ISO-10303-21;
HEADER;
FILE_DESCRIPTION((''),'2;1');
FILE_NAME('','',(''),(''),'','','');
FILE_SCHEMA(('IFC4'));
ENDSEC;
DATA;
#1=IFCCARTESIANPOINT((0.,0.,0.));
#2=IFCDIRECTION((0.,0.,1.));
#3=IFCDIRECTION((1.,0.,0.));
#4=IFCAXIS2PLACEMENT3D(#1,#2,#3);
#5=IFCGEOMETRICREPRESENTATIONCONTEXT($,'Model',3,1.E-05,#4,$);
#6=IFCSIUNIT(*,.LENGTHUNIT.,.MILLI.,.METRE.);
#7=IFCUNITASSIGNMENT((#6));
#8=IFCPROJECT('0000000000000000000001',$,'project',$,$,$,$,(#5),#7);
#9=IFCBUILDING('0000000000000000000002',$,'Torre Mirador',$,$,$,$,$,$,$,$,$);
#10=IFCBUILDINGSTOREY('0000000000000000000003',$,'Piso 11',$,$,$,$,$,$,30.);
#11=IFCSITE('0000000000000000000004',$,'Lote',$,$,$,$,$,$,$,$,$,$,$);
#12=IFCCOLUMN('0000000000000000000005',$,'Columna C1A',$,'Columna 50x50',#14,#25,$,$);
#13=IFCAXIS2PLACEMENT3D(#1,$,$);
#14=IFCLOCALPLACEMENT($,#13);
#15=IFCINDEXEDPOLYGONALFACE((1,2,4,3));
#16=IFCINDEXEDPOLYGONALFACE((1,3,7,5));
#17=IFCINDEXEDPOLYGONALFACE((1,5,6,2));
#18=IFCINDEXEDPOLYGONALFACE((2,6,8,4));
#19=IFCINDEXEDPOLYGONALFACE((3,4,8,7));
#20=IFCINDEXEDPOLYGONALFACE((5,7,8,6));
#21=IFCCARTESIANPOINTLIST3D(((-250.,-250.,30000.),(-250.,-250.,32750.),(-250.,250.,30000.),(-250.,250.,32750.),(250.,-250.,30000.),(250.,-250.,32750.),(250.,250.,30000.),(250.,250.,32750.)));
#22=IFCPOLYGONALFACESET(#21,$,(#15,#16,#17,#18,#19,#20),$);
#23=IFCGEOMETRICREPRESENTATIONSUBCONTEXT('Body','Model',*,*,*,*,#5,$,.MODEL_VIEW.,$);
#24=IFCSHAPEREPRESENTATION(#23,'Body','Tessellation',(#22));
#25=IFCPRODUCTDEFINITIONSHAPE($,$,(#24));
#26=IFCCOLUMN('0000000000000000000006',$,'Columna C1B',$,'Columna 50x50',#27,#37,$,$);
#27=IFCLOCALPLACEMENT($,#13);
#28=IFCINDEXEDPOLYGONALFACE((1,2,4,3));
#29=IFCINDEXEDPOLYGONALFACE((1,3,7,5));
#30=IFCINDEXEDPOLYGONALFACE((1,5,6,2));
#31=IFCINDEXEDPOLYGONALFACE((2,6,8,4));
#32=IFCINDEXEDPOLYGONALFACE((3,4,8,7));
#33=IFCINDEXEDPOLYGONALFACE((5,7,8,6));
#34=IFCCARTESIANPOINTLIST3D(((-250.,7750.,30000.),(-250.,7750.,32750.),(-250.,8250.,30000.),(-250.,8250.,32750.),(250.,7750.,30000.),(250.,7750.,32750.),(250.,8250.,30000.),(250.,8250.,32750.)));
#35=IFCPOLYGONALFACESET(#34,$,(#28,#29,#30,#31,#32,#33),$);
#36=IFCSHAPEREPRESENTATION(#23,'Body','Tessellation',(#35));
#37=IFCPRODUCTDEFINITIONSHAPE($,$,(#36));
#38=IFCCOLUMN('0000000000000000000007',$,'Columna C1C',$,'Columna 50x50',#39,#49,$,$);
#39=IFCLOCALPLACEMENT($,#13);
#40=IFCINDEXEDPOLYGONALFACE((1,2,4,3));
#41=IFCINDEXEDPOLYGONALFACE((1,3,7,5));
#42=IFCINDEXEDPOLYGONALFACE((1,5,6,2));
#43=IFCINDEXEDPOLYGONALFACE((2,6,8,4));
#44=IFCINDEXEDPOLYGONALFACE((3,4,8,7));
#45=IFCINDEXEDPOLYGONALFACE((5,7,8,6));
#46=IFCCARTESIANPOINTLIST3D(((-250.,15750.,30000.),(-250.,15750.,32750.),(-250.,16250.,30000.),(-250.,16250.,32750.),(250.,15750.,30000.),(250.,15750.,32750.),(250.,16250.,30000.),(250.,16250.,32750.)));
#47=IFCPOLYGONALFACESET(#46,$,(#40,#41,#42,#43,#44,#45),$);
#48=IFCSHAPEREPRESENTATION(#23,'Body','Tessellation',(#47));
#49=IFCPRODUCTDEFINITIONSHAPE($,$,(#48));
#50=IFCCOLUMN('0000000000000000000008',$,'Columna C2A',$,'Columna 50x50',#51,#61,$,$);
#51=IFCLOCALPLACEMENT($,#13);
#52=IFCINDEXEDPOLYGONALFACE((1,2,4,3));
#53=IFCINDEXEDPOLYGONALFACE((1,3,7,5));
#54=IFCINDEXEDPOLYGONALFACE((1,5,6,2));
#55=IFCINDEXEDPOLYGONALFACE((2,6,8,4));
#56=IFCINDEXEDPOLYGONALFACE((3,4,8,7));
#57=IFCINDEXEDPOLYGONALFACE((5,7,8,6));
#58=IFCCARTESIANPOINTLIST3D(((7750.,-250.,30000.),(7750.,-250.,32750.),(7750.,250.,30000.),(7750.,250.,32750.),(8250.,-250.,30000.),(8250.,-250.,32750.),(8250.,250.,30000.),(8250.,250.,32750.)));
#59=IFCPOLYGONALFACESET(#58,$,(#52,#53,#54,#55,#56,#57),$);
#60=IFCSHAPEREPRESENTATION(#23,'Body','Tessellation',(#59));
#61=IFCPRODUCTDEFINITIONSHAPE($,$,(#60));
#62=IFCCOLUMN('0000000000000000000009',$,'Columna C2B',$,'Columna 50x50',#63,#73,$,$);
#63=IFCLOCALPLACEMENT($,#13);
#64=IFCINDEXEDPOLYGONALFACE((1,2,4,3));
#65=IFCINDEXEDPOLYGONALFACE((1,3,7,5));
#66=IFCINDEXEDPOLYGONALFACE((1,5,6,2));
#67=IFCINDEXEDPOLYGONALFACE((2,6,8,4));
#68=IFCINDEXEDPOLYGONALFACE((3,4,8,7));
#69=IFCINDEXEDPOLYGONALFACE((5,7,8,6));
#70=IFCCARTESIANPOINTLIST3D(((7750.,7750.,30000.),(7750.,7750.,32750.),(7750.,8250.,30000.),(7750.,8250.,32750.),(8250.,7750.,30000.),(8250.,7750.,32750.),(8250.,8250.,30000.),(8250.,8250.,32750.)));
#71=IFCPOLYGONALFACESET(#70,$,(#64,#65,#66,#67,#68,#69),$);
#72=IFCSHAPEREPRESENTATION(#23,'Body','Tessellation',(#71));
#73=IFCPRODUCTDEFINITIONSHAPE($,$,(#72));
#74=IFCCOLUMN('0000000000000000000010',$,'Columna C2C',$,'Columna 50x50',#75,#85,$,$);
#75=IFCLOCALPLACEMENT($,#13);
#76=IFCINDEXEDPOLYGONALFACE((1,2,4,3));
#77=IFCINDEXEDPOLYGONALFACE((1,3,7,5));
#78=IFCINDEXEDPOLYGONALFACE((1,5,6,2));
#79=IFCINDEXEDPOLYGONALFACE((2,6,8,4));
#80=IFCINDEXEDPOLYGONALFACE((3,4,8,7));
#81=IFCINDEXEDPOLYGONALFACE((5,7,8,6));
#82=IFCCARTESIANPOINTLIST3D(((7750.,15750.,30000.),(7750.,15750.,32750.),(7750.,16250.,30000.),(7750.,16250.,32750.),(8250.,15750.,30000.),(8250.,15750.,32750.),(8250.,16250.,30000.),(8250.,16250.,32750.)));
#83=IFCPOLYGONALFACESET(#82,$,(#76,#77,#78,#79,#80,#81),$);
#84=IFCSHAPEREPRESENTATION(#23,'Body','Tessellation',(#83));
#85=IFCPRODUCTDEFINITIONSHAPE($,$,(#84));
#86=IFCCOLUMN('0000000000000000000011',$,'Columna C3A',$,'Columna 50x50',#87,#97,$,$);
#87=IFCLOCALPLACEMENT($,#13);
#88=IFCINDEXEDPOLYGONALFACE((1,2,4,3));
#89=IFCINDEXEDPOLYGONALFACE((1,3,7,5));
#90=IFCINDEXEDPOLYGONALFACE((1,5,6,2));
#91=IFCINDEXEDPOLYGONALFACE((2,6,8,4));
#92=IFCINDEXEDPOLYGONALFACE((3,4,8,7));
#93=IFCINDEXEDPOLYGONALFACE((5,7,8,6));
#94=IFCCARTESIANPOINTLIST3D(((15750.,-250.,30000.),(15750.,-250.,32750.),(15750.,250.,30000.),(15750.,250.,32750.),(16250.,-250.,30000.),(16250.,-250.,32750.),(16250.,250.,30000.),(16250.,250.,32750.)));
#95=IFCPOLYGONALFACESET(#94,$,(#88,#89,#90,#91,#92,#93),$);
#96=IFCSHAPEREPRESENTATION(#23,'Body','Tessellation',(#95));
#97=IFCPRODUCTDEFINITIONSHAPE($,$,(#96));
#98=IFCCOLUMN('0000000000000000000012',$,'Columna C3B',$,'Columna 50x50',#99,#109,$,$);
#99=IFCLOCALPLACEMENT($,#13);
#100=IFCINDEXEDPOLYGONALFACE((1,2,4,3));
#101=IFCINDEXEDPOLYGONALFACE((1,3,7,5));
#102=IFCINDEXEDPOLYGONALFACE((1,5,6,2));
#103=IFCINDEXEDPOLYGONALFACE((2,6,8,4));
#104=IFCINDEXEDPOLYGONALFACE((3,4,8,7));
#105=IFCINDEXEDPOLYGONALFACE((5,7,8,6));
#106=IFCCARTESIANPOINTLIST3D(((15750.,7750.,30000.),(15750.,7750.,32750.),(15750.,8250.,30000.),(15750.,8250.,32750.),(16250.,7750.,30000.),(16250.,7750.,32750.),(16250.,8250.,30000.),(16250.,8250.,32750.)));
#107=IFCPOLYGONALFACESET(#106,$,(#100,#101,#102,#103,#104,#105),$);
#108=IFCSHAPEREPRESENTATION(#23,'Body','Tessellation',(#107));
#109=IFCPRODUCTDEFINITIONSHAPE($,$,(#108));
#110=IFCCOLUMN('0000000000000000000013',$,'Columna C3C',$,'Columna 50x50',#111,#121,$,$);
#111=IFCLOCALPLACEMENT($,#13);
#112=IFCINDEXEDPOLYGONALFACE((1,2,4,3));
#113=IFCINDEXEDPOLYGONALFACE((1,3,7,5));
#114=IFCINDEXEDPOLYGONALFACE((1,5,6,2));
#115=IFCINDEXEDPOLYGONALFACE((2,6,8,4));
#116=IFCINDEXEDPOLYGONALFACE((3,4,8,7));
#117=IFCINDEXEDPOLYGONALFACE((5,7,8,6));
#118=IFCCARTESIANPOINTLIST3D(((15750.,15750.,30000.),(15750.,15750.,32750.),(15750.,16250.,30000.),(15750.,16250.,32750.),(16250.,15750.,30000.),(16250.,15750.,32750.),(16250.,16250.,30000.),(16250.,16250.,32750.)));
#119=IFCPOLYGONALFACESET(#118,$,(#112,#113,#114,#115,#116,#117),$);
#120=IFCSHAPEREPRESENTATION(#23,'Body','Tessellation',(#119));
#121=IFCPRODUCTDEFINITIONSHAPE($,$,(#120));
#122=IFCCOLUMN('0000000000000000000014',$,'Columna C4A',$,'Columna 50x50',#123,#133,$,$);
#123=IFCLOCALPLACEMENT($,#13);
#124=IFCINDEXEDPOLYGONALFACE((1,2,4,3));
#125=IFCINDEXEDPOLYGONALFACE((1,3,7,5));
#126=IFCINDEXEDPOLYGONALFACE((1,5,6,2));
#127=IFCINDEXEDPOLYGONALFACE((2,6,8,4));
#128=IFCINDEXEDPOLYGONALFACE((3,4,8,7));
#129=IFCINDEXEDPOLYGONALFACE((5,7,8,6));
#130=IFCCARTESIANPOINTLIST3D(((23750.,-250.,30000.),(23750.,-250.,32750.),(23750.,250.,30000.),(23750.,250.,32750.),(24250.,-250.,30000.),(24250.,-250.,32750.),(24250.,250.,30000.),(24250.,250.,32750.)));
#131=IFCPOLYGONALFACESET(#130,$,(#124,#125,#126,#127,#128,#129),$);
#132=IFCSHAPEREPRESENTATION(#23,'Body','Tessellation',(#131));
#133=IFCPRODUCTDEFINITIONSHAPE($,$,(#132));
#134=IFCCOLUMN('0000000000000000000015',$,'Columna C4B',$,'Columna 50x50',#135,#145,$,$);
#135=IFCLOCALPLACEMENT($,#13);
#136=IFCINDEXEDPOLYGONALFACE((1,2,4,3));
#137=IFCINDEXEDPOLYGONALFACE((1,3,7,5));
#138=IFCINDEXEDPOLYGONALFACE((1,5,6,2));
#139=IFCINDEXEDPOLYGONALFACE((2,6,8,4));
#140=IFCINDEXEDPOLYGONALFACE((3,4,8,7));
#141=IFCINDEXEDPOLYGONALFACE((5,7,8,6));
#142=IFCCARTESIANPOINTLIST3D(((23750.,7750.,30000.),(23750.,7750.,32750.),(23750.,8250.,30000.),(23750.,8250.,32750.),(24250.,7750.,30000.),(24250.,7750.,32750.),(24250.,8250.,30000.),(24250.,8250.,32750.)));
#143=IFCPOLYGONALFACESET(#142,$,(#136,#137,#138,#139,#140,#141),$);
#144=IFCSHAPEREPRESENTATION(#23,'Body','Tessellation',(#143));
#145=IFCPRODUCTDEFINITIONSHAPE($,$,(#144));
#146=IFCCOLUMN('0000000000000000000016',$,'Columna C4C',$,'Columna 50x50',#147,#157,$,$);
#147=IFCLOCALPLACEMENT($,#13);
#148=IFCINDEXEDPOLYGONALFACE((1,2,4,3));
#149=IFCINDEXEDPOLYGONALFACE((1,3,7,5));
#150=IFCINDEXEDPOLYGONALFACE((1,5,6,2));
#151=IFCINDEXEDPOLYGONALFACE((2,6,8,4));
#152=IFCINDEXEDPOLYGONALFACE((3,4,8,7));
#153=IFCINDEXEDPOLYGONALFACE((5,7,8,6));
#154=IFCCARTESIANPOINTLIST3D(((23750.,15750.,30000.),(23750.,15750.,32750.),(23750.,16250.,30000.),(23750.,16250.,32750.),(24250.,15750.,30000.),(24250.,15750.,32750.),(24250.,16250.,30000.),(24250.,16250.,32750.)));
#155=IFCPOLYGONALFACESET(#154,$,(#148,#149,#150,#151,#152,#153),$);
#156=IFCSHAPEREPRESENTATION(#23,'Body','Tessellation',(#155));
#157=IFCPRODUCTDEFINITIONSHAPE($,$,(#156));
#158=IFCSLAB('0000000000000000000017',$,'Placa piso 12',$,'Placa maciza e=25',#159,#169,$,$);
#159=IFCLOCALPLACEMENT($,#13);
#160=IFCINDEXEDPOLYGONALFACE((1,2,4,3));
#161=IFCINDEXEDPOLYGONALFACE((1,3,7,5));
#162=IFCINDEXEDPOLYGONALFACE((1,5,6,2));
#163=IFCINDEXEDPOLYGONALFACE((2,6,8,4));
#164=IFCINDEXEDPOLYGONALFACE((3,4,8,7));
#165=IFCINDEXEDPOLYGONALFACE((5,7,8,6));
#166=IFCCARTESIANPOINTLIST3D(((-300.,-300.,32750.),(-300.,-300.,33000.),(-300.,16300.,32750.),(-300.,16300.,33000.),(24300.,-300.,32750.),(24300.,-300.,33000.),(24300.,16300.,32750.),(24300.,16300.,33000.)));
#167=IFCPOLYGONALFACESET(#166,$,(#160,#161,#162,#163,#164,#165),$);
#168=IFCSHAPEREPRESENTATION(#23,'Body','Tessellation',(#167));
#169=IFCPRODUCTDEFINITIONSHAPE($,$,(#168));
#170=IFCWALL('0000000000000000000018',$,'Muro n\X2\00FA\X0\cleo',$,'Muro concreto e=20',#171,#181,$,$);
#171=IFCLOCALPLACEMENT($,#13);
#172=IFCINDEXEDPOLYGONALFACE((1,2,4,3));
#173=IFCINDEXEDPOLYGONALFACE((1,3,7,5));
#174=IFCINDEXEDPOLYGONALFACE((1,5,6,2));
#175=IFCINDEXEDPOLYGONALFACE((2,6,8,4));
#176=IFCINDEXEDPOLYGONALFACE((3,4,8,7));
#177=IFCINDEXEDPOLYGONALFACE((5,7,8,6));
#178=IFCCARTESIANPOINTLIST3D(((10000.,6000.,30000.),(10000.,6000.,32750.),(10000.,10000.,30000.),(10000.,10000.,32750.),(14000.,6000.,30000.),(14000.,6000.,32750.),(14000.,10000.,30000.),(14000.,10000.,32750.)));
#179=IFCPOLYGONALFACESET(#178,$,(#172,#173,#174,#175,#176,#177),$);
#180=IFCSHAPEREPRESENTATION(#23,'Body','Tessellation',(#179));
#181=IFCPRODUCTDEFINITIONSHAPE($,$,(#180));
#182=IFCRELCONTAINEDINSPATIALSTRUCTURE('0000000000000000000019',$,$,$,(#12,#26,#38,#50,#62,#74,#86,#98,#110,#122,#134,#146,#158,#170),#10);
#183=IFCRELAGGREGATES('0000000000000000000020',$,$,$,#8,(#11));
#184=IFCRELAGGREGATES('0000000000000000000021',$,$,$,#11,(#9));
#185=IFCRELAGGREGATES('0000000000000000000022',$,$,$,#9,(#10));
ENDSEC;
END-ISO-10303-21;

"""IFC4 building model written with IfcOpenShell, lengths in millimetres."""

from ifc_helpers import new_model, si_unit, frame, origin_with_axes, place, context, subcontext, project, spatial, indexed_curve, outline, extrude, element, save


model = new_model("IFC4")

# Units and contexts
model_context = context("Model", 3, precision=1e-05, world=origin_with_axes())
body_context = subcontext(model_context, "Body", "Model", "MODEL_VIEW")
ifc_project = project(units=[si_unit("LENGTHUNIT", "METRE", prefix="MILLI")], contexts=[model_context])

# Site, building, storey
site = spatial("IfcSite", under=ifc_project, Name="Lote")
building = spatial("IfcBuilding", under=site, Name="Torre Mirador")
storey = spatial("IfcBuildingStorey", under=building, Name="Piso 11", Elevation=30.0)

# Columns
for number, where, z_axis, x_axis, name in (
    (1, (-250.0, -250.0, 30000.0), (0.0, 0.0, 1.0), (1.0, 0.0, 0.0), "Columna C1A"),
    (2, (-250.0, 7750.0, 30000.0), (0.0, 0.0, 1.0), (1.0, 0.0, 0.0), "Columna C1B"),
    (3, (-250.0, 15750.0, 30000.0), (0.0, 0.0, 1.0), (1.0, 0.0, 0.0), "Columna C1C"),
    (4, (7750.0, -250.0, 30000.0), (0.0, 0.0, 1.0), (1.0, 0.0, 0.0), "Columna C2A"),
    (5, (7750.0, 7750.0, 30000.0), (0.0, 0.0, 1.0), (1.0, 0.0, 0.0), "Columna C2B"),
    (6, (7750.0, 15750.0, 30000.0), (0.0, 0.0, 1.0), (1.0, 0.0, 0.0), "Columna C2C"),
    (7, (15750.0, -250.0, 30000.0), (0.0, 0.0, 1.0), (1.0, 0.0, 0.0), "Columna C3A"),
    (8, (15750.0, 7750.0, 30000.0), (0.0, 0.0, 1.0), (1.0, 0.0, 0.0), "Columna C3B"),
    (9, (15750.0, 15750.0, 30000.0), (0.0, 0.0, 1.0), (1.0, 0.0, 0.0), "Columna C3C"),
    (10, (23750.0, -250.0, 30000.0), (0.0, 0.0, 1.0), (1.0, 0.0, 0.0), "Columna C4A"),
    (11, (23750.0, 7750.0, 30000.0), (0.0, 0.0, 1.0), (1.0, 0.0, 0.0), "Columna C4B"),
    (12, (23750.0, 15750.0, 30000.0), (0.0, 0.0, 1.0), (1.0, 0.0, 0.0), "Columna C4C"),
):
    element("IfcColumn", number, at=place(None, frame(where, z_axis=z_axis, x_axis=x_axis)), inside=storey, Name=name, ObjectType="Columna 50x50", context=body_context, shape_type="SweptSolid", body=[
        extrude(outline(indexed_curve([(0.0, 0.0), (0.0, 500.0), (500.0, 500.0), (500.0, 0.0), (0.0, 0.0)], self_intersect=False)), origin_with_axes(), (0.0, 0.0, 1.0), 2750.0),
    ])

# Slab
slab_placement = place(None, frame((-300.0, -300.0, 32750.0), z_axis=(0.0, 0.0, 1.0), x_axis=(1.0, 0.0, 0.0)))
element("IfcSlab", 13, at=slab_placement, inside=storey, Name="Placa piso 12", ObjectType="Placa maciza e=25", context=body_context, shape_type="SweptSolid", body=[
    extrude(outline(indexed_curve([(0.0, 0.0), (0.0, 16600.0), (24600.0, 16600.0), (24600.0, 0.0), (0.0, 0.0)], self_intersect=False)), origin_with_axes(), (0.0, 0.0, 1.0), 250.0),
])

# Wall
wall_placement = place(None, frame((10000.0, 6000.0, 30000.0), z_axis=(0.0, 0.0, 1.0), x_axis=(1.0, 0.0, 0.0)))
element("IfcWall", 14, at=wall_placement, inside=storey, Name="Muro núcleo", ObjectType="Muro concreto e=20", context=body_context, shape_type="SweptSolid", body=[
    extrude(outline(indexed_curve([(0.0, 0.0), (0.0, 4000.0), (4000.0, 4000.0), (4000.0, 0.0), (0.0, 0.0)], self_intersect=False)), origin_with_axes(), (0.0, 0.0, 1.0), 2750.0),
])

save(model, "model.ifc")
